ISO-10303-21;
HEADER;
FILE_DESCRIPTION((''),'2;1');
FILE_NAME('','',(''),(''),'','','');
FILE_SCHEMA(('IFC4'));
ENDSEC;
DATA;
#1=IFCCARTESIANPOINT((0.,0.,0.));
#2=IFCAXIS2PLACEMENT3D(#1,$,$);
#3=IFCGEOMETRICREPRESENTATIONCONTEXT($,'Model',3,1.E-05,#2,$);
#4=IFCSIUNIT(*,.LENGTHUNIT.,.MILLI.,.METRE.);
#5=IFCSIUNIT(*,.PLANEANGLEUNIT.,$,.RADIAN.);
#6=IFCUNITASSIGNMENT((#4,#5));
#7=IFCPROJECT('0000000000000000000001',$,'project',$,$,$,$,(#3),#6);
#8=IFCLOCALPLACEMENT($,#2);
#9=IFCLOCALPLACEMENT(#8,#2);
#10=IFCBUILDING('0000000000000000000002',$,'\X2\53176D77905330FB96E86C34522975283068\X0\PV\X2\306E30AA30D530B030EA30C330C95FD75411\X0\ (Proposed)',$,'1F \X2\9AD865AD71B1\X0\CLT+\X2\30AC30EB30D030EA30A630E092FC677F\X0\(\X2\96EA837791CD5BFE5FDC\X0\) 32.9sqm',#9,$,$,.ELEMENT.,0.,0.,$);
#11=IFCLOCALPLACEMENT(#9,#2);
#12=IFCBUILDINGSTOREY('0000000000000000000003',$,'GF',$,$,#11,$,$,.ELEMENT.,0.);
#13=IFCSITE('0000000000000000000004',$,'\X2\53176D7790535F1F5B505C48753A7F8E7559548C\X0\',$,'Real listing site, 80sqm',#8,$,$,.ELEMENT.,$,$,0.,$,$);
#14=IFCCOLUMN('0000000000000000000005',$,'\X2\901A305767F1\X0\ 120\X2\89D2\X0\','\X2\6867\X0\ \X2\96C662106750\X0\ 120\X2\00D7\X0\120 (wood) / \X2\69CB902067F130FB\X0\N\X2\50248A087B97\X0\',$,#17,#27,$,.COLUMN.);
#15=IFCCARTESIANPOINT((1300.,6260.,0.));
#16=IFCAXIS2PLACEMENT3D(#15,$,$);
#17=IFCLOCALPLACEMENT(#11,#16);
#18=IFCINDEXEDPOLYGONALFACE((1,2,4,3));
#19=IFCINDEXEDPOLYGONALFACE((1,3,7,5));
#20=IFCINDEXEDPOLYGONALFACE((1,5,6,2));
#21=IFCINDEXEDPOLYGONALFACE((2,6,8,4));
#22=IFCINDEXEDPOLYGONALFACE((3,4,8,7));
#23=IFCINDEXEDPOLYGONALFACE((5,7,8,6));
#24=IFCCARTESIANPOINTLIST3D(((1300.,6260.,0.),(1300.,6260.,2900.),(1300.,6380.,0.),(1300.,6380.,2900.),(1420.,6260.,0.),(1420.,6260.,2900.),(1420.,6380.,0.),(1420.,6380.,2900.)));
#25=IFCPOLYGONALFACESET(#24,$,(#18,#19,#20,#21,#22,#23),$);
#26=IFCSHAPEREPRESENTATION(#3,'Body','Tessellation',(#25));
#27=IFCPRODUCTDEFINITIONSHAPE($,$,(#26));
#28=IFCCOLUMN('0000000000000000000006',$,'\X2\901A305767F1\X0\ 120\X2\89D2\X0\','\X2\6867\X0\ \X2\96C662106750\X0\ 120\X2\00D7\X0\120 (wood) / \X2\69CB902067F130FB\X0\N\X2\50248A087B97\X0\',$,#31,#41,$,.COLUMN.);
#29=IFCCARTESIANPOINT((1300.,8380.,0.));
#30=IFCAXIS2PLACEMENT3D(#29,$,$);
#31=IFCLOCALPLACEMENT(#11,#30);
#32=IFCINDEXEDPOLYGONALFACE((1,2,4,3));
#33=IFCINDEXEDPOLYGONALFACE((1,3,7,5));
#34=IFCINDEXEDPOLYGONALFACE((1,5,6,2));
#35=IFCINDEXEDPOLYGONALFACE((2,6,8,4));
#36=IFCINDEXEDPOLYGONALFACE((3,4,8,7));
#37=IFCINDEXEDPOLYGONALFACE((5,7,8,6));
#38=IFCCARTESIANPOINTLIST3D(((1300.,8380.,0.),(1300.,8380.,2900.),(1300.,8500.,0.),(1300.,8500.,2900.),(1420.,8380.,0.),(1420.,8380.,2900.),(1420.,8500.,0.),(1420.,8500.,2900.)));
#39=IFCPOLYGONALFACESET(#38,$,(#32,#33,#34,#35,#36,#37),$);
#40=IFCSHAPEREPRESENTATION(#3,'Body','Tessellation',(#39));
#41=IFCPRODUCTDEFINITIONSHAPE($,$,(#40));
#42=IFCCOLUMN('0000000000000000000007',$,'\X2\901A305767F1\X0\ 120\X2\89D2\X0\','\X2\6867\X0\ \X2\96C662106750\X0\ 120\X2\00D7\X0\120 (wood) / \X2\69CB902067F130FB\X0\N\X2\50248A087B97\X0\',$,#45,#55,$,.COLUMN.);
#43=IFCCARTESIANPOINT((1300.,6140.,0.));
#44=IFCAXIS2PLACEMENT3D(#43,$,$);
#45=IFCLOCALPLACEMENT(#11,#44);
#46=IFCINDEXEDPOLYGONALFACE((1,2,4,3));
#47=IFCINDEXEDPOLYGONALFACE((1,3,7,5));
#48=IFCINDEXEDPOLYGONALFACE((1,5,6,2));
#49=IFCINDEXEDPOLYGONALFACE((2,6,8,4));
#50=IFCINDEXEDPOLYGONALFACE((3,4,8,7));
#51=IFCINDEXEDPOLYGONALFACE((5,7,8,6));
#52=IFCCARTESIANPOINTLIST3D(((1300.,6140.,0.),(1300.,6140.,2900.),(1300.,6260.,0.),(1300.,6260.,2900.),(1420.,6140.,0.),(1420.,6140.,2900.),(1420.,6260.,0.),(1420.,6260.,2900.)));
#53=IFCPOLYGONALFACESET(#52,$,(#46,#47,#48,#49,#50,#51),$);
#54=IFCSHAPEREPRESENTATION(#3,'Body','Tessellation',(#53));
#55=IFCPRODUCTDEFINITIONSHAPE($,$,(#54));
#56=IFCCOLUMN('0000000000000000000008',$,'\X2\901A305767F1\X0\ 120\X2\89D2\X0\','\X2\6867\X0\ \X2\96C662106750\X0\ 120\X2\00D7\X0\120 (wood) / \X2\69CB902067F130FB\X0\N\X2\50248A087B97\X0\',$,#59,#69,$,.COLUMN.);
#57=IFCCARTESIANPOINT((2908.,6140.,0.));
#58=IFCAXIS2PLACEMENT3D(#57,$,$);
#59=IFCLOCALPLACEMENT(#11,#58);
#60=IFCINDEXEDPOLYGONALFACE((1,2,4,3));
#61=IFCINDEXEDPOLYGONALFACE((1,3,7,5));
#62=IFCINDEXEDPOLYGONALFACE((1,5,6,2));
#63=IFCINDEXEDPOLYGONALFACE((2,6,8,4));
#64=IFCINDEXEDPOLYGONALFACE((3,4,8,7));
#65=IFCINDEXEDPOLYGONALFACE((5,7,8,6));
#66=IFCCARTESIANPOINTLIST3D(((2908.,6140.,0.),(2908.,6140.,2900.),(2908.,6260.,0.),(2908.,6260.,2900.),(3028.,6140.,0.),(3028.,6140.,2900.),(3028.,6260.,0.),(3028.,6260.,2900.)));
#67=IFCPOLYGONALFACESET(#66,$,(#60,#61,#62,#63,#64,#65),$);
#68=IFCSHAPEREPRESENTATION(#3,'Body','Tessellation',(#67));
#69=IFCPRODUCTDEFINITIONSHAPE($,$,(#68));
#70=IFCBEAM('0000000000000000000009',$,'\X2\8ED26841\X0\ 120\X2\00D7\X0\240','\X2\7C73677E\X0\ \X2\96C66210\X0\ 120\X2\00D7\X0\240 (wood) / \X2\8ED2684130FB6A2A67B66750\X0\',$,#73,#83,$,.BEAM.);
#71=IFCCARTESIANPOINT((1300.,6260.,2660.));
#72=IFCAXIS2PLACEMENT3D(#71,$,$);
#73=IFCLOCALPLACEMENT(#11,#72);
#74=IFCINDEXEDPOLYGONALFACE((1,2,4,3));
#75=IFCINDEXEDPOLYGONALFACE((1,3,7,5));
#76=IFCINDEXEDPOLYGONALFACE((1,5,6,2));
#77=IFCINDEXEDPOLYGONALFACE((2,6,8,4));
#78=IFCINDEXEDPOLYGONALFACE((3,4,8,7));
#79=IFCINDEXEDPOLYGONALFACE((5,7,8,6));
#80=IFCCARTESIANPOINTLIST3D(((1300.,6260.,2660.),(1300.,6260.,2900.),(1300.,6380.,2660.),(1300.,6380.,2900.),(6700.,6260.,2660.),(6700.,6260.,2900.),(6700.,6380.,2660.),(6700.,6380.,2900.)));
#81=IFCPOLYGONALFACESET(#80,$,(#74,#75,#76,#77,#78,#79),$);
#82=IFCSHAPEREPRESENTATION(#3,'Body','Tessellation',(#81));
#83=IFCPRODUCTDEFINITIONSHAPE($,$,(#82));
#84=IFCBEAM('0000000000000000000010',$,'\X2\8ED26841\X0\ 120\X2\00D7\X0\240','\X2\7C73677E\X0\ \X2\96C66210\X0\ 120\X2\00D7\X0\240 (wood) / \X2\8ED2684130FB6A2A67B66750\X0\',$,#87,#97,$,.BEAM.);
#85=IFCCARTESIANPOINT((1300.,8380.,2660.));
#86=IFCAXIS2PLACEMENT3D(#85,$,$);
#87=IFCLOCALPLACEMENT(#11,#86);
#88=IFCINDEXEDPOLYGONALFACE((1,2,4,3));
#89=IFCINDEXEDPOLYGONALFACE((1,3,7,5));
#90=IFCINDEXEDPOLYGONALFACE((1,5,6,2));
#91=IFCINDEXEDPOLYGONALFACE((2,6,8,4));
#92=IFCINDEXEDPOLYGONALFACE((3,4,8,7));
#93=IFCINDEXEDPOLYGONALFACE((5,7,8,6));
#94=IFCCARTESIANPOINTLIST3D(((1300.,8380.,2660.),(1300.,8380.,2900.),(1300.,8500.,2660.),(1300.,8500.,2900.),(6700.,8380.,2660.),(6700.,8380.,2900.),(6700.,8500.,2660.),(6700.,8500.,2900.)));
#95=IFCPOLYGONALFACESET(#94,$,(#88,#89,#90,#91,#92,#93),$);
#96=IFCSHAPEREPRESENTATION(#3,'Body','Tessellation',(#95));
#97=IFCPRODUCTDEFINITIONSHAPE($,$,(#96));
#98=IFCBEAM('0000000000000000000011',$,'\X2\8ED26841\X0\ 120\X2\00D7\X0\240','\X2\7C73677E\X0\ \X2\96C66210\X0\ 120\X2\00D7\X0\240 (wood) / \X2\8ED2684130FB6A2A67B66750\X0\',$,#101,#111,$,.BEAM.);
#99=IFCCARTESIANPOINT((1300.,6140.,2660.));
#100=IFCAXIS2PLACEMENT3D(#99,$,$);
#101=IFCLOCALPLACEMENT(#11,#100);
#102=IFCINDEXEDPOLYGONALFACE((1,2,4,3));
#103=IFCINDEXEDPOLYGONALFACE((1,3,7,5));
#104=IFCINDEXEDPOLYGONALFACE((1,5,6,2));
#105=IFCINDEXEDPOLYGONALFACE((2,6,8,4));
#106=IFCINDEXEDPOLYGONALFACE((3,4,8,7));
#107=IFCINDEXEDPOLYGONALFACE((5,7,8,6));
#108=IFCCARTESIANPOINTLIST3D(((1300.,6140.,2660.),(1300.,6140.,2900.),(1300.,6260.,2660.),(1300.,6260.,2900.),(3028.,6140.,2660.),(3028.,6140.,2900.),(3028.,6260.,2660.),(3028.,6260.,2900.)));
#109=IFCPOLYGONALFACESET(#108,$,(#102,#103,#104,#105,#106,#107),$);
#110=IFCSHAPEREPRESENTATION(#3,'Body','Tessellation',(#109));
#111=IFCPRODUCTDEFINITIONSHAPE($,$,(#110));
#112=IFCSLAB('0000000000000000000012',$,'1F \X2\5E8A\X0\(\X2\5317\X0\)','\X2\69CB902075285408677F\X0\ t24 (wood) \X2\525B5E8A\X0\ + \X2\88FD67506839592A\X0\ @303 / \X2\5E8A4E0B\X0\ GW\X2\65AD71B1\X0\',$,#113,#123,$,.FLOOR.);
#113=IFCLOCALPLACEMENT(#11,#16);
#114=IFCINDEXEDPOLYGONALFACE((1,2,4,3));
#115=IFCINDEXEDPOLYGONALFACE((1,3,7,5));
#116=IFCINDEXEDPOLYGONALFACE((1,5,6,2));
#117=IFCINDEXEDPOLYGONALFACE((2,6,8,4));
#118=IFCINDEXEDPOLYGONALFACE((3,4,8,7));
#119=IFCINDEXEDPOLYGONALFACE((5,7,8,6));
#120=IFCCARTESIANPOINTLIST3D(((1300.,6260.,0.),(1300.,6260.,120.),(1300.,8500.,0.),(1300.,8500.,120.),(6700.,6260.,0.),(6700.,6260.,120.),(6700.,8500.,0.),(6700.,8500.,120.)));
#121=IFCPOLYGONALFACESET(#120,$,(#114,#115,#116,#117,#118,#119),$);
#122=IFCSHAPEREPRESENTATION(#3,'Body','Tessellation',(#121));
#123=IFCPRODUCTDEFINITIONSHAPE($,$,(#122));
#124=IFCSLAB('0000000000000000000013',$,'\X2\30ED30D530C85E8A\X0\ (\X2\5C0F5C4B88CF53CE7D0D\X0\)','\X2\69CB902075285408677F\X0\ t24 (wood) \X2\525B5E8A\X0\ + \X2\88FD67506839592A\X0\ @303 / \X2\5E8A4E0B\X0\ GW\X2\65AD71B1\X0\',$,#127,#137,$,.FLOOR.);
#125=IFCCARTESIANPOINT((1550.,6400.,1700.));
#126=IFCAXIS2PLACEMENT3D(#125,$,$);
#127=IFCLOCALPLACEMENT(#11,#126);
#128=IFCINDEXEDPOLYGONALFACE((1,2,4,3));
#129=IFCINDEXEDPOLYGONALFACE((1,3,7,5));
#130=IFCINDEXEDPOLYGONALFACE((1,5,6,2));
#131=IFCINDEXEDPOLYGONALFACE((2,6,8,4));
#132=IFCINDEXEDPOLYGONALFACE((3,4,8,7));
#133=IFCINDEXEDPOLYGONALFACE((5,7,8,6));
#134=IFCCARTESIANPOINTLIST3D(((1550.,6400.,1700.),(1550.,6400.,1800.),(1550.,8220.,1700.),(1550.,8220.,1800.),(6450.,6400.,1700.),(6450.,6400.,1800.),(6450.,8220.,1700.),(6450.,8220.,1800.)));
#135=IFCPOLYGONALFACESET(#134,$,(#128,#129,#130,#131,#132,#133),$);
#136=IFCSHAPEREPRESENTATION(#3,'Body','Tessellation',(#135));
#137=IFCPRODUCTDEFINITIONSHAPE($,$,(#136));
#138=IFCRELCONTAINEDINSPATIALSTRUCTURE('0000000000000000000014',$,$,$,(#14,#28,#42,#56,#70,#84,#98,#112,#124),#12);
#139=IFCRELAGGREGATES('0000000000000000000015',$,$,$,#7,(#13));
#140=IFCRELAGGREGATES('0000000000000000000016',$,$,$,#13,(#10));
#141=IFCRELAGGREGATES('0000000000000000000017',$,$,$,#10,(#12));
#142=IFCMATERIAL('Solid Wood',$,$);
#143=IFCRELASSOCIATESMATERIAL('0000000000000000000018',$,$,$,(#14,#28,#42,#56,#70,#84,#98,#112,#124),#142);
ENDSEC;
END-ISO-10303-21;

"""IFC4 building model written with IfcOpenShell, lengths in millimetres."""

from ifc_helpers import new_model, si_unit, frame, frame_2d, origin, place, context, project, spatial, rectangle, extrude, material, element, save


model = new_model("IFC4")

# Units and contexts
model_context = context("Model", 3, precision=1e-05, world=origin())
ifc_project = project(units=[si_unit("LENGTHUNIT", "METRE", prefix="MILLI"), si_unit("PLANEANGLEUNIT", "RADIAN")], contexts=[model_context])

# Site, building, storey
site_placement = place(None, origin())
site = spatial("IfcSite", under=ifc_project, at=site_placement, Name="北海道弟子屈町美留和", ObjectType="Real listing site, 80sqm", CompositionType="ELEMENT", RefElevation=0.0)
building_placement = place(site_placement, origin())
building = spatial("IfcBuilding", under=site, at=building_placement, Name="北海道・雨水利用とPVのオフグリッド志向 (Proposed)", ObjectType="1F 高断熱CLT+ガルバリウム鋼板(雪荷重対応) 32.9sqm", CompositionType="ELEMENT", ElevationOfRefHeight=0.0, ElevationOfTerrain=0.0)
storey_placement = place(building_placement, origin())
storey = spatial("IfcBuildingStorey", under=building, at=storey_placement, Name="GF", CompositionType="ELEMENT", Elevation=0.0)

# Columns
ifc_material_1 = material(Name="Solid Wood")
column_1_placement = place(storey_placement, frame((1300.0, 6260.0, 0.0)))
element("IfcColumn", 1, at=column_1_placement, inside=storey, material=ifc_material_1, Name="通し柱 120角", Description="桧 集成材 120×120 (wood) / 構造柱・N値計算", PredefinedType="COLUMN", context=model_context, shape_type="SweptSolid", body=[
    extrude(rectangle(XDim=120.0, YDim=120.0, at=frame_2d((60.0, 60.0))), frame((1300.0, 6260.0, 0.0)), (0.0, 0.0, 1.0), 2900.0),
])
column_2_placement = place(storey_placement, frame((1300.0, 8380.0, 0.0)))
element("IfcColumn", 2, at=column_2_placement, inside=storey, material=ifc_material_1, Name="通し柱 120角", Description="桧 集成材 120×120 (wood) / 構造柱・N値計算", PredefinedType="COLUMN", context=model_context, shape_type="SweptSolid", body=[
    extrude(rectangle(XDim=120.0, YDim=120.0, at=frame_2d((60.0, 60.0))), frame((1300.0, 8380.0, 0.0)), (0.0, 0.0, 1.0), 2900.0),
])
column_3_placement = place(storey_placement, frame((1300.0, 6140.0, 0.0)))
element("IfcColumn", 3, at=column_3_placement, inside=storey, material=ifc_material_1, Name="通し柱 120角", Description="桧 集成材 120×120 (wood) / 構造柱・N値計算", PredefinedType="COLUMN", context=model_context, shape_type="SweptSolid", body=[
    extrude(rectangle(XDim=120.0, YDim=120.0, at=frame_2d((60.0, 60.0))), frame((1300.0, 6140.0, 0.0)), (0.0, 0.0, 1.0), 2900.0),
])
column_4_placement = place(storey_placement, frame((2908.0, 6140.0, 0.0)))
element("IfcColumn", 4, at=column_4_placement, inside=storey, material=ifc_material_1, Name="通し柱 120角", Description="桧 集成材 120×120 (wood) / 構造柱・N値計算", PredefinedType="COLUMN", context=model_context, shape_type="SweptSolid", body=[
    extrude(rectangle(XDim=120.0, YDim=120.0, at=frame_2d((60.0, 60.0))), frame((2908.0, 6140.0, 0.0)), (0.0, 0.0, 1.0), 2900.0),
])

# Beams
beam_1_placement = place(storey_placement, frame((1300.0, 6260.0, 2660.0)))
element("IfcBeam", 5, at=beam_1_placement, inside=storey, material=ifc_material_1, Name="軒桁 120×240", Description="米松 集成 120×240 (wood) / 軒桁・横架材", PredefinedType="BEAM", context=model_context, shape_type="SweptSolid", body=[
    extrude(rectangle(XDim=5400.0, YDim=120.0, at=frame_2d((2700.0, 60.0))), frame((1300.0, 6260.0, 2660.0)), (0.0, 0.0, 1.0), 240.0),
])
beam_2_placement = place(storey_placement, frame((1300.0, 8380.0, 2660.0)))
element("IfcBeam", 6, at=beam_2_placement, inside=storey, material=ifc_material_1, Name="軒桁 120×240", Description="米松 集成 120×240 (wood) / 軒桁・横架材", PredefinedType="BEAM", context=model_context, shape_type="SweptSolid", body=[
    extrude(rectangle(XDim=5400.0, YDim=120.0, at=frame_2d((2700.0, 60.0))), frame((1300.0, 8380.0, 2660.0)), (0.0, 0.0, 1.0), 240.0),
])
beam_3_placement = place(storey_placement, frame((1300.0, 6140.0, 2660.0)))
element("IfcBeam", 7, at=beam_3_placement, inside=storey, material=ifc_material_1, Name="軒桁 120×240", Description="米松 集成 120×240 (wood) / 軒桁・横架材", PredefinedType="BEAM", context=model_context, shape_type="SweptSolid", body=[
    extrude(rectangle(XDim=1728.0, YDim=120.0, at=frame_2d((864.0, 60.0))), frame((1300.0, 6140.0, 2660.0)), (0.0, 0.0, 1.0), 240.0),
])

# Slabs
slab_1_placement = place(storey_placement, frame((1300.0, 6260.0, 0.0)))
element("IfcSlab", 8, at=slab_1_placement, inside=storey, material=ifc_material_1, Name="1F 床(北)", Description="構造用合板 t24 (wood) 剛床 + 製材根太 @303 / 床下 GW断熱", PredefinedType="FLOOR", context=model_context, shape_type="SweptSolid", body=[
    extrude(rectangle(XDim=5400.0, YDim=2240.0, at=frame_2d((2700.0, 1120.0))), frame((1300.0, 6260.0, 0.0)), (0.0, 0.0, 1.0), 120.0),
])
slab_2_placement = place(storey_placement, frame((1550.0, 6400.0, 1700.0)))
element("IfcSlab", 9, at=slab_2_placement, inside=storey, material=ifc_material_1, Name="ロフト床 (小屋裏収納)", Description="構造用合板 t24 (wood) 剛床 + 製材根太 @303 / 床下 GW断熱", PredefinedType="FLOOR", context=model_context, shape_type="SweptSolid", body=[
    extrude(rectangle(XDim=4900.0, YDim=1820.0, at=frame_2d((2450.0, 910.0))), frame((1550.0, 6400.0, 1700.0)), (0.0, 0.0, 1.0), 100.0),
])

save(model, "model.ifc")
